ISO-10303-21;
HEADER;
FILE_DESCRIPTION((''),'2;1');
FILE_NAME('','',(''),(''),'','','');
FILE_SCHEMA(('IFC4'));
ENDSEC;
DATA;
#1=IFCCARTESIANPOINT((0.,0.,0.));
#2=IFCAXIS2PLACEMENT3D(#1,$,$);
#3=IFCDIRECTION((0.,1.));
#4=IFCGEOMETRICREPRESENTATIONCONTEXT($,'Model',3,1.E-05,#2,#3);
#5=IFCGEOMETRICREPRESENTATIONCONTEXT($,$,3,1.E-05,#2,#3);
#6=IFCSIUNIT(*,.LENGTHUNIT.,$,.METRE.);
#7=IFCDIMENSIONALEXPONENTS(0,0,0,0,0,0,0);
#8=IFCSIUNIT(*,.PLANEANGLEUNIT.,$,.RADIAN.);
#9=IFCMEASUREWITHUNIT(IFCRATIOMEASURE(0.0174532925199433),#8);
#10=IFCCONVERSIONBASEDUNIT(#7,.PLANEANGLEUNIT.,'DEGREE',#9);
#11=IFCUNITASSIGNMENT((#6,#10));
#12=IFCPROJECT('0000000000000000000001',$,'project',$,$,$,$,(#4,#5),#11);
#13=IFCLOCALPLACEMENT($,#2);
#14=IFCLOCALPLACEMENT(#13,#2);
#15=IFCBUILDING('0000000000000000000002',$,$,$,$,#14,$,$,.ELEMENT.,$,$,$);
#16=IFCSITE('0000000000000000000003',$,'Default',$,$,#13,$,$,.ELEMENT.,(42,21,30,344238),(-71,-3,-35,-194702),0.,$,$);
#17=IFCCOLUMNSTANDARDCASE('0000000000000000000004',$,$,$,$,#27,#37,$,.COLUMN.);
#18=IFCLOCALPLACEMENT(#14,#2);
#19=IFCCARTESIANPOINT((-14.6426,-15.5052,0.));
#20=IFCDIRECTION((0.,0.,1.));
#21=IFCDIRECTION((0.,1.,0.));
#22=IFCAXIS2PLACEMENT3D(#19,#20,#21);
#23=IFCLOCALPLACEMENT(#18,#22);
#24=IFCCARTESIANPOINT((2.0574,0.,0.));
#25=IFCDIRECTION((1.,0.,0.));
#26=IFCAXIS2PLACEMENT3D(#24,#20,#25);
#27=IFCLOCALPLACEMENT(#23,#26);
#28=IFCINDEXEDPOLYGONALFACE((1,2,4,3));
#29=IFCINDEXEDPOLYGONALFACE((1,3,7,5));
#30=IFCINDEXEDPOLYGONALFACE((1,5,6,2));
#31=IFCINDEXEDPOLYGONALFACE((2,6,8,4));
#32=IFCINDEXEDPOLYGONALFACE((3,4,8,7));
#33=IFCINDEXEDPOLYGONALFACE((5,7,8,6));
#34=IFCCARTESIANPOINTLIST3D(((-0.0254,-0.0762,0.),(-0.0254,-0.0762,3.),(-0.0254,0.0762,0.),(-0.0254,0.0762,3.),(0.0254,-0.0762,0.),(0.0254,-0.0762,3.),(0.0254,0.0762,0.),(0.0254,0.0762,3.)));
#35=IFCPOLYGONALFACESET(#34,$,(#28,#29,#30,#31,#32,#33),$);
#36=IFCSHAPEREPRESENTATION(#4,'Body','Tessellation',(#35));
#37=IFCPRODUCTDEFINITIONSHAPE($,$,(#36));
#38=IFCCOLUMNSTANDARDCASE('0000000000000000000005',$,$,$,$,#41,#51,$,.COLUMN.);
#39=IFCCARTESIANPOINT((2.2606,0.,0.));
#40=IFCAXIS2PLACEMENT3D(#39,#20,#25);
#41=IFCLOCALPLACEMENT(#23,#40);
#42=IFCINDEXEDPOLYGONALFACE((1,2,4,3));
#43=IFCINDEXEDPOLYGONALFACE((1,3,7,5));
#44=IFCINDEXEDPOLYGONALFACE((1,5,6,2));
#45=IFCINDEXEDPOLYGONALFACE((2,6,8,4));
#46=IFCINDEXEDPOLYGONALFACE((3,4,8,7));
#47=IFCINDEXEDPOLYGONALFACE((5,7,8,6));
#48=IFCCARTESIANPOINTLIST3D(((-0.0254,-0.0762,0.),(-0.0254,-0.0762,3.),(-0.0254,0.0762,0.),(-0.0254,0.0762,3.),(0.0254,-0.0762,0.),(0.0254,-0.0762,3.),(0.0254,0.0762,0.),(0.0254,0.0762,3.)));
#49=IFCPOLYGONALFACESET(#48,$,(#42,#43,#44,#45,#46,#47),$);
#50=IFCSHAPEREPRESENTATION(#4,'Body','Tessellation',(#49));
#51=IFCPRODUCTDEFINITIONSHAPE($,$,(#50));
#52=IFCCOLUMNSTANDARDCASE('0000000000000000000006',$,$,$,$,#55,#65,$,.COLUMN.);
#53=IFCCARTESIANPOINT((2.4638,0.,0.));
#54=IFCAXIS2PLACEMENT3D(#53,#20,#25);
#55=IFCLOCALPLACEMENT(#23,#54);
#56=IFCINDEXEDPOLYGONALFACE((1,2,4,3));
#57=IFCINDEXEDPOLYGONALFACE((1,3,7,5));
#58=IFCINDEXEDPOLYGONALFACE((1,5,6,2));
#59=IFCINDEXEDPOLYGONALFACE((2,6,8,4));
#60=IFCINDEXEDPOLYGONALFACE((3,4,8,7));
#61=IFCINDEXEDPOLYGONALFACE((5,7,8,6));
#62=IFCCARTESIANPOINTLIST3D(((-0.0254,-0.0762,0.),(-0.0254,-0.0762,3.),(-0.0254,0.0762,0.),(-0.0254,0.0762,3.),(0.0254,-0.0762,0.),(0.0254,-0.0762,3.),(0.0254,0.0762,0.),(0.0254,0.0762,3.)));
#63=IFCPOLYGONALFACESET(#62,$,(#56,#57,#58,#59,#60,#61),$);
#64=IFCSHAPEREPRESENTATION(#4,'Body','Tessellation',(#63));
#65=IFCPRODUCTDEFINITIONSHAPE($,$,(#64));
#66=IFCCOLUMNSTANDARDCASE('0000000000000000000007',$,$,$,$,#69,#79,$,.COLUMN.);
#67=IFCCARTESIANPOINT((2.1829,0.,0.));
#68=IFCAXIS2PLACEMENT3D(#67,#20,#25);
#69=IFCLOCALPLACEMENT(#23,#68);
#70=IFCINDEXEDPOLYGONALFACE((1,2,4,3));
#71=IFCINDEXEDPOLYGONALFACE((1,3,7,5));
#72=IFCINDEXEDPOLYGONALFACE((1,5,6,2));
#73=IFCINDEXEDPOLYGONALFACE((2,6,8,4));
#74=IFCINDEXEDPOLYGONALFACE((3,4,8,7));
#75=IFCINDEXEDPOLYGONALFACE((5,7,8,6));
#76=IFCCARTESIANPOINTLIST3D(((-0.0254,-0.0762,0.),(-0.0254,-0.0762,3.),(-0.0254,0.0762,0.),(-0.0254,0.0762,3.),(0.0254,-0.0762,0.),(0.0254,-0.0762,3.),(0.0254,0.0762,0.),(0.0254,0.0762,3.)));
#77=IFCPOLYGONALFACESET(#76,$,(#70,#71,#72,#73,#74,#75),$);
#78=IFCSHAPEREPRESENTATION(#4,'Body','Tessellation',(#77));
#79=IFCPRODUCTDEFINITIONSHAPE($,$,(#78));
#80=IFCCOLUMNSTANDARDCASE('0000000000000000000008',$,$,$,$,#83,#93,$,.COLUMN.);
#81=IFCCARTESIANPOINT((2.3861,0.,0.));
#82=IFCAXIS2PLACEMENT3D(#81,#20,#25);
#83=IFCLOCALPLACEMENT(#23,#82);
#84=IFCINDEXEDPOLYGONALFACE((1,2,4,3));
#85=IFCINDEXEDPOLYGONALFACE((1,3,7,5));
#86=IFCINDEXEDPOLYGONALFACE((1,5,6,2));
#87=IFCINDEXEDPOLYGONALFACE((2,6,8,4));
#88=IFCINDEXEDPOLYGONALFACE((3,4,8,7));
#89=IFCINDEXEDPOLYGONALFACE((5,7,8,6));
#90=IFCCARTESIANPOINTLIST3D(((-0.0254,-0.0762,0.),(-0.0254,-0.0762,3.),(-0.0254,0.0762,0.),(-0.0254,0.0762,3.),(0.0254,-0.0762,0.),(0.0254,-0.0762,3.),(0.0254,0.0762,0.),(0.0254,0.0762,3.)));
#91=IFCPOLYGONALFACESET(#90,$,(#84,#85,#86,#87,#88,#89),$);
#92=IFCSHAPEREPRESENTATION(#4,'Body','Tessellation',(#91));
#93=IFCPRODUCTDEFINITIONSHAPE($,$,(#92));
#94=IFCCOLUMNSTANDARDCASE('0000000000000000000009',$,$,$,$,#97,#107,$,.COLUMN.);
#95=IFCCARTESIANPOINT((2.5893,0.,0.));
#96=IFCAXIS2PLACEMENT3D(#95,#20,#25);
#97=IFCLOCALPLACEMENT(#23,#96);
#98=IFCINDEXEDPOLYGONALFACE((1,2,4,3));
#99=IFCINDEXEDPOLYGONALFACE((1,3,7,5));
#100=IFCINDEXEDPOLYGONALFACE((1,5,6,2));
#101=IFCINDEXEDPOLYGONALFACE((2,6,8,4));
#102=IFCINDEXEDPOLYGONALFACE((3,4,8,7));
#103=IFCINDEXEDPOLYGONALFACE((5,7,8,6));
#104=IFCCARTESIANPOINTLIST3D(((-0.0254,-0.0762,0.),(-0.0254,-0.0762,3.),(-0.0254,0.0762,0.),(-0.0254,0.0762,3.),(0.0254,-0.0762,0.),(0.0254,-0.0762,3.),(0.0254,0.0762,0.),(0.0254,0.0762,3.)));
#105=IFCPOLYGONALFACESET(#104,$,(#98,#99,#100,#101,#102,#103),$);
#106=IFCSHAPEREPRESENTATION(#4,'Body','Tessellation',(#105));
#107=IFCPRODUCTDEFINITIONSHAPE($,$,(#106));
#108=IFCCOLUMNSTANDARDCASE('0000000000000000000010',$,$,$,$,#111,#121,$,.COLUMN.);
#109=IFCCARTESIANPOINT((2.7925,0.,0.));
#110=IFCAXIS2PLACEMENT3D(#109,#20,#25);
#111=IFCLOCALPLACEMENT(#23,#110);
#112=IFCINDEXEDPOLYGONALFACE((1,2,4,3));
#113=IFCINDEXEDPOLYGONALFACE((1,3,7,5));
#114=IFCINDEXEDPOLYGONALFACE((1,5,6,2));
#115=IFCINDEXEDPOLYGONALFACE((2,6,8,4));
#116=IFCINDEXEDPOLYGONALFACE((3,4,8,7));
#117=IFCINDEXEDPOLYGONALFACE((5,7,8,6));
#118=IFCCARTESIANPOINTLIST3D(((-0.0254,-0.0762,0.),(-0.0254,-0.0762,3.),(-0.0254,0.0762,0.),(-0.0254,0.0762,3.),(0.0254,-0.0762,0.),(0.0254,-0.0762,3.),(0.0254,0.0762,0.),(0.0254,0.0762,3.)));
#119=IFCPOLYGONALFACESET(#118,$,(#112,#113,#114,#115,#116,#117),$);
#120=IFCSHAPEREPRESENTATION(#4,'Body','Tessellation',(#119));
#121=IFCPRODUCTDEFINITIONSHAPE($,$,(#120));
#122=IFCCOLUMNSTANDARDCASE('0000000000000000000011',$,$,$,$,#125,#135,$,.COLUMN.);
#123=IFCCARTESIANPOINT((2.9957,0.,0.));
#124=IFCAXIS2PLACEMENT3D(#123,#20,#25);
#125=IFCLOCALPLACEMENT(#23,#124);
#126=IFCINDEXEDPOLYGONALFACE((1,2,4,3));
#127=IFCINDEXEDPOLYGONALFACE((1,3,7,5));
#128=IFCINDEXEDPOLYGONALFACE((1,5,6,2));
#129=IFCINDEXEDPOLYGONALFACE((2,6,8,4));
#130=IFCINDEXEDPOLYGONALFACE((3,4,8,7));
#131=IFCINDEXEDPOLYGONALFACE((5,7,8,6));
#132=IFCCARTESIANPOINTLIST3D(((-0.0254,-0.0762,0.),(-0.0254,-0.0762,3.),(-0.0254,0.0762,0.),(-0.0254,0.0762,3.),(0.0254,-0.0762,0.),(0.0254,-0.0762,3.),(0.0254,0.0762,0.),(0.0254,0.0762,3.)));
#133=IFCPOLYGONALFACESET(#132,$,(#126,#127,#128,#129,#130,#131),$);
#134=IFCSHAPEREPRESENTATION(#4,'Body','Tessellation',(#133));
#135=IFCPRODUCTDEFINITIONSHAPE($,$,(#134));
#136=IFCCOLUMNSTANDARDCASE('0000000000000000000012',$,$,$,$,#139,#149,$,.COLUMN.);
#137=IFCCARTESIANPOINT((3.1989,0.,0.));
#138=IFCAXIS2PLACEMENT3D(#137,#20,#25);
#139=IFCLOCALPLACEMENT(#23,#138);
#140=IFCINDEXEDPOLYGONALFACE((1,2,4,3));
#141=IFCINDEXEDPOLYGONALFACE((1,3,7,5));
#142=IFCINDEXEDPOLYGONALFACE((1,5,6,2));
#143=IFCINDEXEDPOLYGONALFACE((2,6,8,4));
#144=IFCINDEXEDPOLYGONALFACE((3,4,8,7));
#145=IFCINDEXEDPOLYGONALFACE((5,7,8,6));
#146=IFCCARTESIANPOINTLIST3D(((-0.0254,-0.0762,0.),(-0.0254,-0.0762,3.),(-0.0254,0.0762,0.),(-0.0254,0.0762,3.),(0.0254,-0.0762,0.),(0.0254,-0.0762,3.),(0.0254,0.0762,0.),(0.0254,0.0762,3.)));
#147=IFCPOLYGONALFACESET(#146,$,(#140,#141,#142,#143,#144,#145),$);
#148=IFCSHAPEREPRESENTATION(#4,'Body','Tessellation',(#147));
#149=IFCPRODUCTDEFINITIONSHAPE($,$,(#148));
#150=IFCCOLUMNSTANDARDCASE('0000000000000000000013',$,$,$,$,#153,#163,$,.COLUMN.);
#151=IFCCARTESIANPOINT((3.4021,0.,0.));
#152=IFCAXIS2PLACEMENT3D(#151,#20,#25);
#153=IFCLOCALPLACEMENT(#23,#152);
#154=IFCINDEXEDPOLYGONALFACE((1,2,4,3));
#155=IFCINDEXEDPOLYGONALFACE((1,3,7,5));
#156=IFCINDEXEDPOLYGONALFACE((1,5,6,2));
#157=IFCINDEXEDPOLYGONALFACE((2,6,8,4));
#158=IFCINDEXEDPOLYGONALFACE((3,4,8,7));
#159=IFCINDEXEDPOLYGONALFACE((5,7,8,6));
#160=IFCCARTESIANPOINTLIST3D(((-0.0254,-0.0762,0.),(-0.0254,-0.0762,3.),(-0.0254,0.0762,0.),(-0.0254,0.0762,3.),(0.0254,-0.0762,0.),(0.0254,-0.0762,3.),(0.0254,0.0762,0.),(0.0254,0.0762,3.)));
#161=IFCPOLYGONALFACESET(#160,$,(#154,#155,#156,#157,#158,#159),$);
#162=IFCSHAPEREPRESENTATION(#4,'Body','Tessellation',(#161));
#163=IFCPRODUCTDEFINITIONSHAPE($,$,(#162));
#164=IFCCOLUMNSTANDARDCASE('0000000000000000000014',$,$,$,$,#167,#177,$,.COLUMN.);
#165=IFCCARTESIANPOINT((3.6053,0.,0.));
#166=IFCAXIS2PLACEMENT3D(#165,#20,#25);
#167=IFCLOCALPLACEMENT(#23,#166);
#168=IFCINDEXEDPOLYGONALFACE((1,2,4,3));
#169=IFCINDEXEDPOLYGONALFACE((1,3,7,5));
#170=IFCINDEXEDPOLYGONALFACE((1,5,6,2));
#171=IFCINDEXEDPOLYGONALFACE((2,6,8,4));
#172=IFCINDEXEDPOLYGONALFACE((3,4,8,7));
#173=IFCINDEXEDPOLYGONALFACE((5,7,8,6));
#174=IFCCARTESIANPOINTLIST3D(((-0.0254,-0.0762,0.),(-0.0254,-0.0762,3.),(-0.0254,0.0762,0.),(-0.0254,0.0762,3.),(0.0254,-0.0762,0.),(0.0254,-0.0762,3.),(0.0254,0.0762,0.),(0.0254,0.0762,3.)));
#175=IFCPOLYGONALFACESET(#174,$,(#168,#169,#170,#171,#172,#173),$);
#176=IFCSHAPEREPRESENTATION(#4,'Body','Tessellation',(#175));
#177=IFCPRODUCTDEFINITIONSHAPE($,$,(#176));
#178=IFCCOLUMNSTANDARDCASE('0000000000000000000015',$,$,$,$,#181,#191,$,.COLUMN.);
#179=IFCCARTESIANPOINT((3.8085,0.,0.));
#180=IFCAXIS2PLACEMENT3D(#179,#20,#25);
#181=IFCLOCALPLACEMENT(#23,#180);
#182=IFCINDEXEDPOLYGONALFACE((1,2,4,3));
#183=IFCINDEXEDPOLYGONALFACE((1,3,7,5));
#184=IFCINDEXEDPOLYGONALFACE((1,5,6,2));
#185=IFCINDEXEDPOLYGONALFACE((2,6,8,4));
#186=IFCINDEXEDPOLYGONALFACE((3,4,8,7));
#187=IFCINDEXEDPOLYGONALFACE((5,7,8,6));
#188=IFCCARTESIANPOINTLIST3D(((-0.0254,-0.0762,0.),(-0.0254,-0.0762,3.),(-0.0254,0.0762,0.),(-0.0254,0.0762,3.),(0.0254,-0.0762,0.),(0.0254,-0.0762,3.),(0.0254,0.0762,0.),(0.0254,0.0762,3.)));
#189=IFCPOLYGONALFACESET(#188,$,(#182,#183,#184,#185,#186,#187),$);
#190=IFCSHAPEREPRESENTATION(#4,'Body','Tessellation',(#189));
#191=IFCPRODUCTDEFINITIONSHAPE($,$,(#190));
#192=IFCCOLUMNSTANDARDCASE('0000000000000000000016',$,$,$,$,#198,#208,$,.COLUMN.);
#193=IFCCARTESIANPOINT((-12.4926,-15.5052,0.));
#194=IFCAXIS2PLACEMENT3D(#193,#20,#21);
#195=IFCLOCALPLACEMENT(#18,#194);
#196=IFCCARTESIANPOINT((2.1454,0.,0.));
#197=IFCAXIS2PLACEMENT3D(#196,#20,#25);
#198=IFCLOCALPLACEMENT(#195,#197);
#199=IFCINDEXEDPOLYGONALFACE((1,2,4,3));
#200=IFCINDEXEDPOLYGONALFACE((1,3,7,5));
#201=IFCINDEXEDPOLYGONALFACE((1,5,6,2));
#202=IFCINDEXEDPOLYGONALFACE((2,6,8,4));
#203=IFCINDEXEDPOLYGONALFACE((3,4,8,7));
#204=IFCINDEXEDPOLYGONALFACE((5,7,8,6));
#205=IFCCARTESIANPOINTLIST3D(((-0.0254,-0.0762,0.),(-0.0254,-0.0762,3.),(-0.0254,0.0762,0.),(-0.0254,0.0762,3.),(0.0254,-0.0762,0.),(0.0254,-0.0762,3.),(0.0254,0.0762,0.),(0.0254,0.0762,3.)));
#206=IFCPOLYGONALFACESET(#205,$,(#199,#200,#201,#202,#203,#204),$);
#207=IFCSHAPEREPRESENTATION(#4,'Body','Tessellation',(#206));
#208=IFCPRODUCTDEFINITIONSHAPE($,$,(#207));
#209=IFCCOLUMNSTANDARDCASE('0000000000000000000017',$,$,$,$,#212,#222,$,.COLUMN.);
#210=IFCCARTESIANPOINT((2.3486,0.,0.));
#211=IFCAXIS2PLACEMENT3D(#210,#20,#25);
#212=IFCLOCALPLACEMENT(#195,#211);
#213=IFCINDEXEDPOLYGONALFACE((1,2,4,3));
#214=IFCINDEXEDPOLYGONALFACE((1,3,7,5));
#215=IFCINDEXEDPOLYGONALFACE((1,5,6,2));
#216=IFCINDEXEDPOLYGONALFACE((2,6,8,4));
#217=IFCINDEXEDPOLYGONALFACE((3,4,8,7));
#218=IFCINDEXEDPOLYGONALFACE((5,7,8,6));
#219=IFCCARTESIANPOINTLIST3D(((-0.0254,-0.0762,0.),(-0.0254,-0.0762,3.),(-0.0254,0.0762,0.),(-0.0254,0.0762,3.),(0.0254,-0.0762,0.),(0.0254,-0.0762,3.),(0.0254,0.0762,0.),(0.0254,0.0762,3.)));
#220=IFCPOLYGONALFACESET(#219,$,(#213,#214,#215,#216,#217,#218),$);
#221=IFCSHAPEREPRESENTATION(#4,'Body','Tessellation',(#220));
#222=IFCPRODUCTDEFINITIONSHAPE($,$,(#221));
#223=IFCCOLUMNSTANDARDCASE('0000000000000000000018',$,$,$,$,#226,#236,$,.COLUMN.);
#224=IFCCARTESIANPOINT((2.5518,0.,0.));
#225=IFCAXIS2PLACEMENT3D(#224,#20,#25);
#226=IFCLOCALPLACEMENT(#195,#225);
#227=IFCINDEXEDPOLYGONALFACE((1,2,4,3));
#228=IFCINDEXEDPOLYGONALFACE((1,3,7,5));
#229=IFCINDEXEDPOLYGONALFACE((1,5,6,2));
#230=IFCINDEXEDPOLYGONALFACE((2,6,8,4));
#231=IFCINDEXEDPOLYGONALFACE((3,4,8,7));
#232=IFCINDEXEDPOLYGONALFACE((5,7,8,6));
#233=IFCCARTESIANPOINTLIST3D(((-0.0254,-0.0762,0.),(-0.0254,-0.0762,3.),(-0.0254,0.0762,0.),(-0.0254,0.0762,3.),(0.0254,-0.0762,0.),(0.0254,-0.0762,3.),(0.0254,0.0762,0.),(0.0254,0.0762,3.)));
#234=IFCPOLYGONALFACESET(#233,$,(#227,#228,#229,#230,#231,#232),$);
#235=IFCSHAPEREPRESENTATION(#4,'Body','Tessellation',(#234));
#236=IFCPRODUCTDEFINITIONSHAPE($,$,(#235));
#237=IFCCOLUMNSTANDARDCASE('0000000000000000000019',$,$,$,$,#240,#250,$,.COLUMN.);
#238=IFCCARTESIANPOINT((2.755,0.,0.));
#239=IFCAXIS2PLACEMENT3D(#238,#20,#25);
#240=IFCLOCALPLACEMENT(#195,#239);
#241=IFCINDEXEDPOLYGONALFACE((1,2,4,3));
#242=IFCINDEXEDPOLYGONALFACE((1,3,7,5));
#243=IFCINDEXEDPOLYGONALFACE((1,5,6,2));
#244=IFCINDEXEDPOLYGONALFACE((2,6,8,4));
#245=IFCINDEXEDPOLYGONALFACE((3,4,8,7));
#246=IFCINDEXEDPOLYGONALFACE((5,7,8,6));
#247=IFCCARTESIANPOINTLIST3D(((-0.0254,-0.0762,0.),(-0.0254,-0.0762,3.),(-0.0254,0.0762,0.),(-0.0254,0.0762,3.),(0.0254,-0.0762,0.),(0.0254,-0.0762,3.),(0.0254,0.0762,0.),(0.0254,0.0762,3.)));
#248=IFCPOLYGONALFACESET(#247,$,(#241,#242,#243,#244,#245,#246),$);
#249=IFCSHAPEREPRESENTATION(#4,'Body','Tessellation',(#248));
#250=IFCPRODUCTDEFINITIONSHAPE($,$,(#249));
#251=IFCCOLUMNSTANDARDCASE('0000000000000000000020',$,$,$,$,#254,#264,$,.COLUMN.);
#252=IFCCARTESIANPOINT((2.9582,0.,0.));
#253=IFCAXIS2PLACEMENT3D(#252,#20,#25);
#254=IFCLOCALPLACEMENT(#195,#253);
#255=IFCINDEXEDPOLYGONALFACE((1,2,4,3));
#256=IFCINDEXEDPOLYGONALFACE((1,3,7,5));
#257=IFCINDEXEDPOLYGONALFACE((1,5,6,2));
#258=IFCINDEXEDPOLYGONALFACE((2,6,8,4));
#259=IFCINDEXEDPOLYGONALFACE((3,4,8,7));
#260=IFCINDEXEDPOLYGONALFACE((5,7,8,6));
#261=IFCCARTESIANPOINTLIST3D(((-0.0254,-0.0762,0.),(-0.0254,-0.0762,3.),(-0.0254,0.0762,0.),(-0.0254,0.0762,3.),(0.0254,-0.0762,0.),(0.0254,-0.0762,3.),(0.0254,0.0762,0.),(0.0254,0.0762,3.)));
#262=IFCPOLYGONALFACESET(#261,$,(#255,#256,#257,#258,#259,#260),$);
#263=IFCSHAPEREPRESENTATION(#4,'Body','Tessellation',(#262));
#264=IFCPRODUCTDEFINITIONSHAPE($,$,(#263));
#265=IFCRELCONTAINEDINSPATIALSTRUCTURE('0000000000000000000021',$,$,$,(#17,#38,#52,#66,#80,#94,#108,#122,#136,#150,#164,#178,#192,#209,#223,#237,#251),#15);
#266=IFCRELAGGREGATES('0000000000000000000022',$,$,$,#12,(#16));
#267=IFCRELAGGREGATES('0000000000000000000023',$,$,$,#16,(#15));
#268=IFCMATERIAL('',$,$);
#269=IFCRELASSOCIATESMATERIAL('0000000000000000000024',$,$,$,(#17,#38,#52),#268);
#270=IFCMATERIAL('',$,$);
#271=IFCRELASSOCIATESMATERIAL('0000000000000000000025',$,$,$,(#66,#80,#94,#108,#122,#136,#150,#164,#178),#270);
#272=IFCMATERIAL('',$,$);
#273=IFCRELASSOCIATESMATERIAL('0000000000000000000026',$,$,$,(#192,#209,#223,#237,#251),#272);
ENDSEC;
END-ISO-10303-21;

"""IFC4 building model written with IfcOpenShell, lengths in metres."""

from ifc_helpers import new_model, entity, si_unit, converted_unit, direction, frame, origin, place, context, project, spatial, rectangle, extrude, material, element, save


model = new_model("IFC4")

# Units and contexts
model_context = context("Model", 3, precision=1e-05, world=origin(), true_north=direction((0.0, 1.0)))
context_of_model = context(None, 3, precision=1e-05, world=origin(), true_north=direction((0.0, 1.0)))
ifc_project = project(units=[si_unit("LENGTHUNIT", "METRE"), converted_unit("PLANEANGLEUNIT", "DEGREE", entity("IfcRatioMeasure", 0.0174532925199433), si_unit("PLANEANGLEUNIT", "RADIAN"), dimensions=[0, 0, 0, 0, 0, 0, 0])], contexts=[model_context, context_of_model])

# Site, building
site_placement = place(None, origin())
site = spatial("IfcSite", under=ifc_project, at=site_placement, Name="Default", CompositionType="ELEMENT", RefLatitude=(42, 21, 30, 344238), RefLongitude=(-71, -3, -35, -194702), RefElevation=0.0)
building_placement = place(site_placement, origin())
building = spatial("IfcBuilding", under=site, at=building_placement, CompositionType="ELEMENT")

# Columns
ifc_material_1 = material(Name="")
placement_1 = place(building_placement, origin())
placement_2 = place(placement_1, frame((-14.6426, -15.5052, 0.0), z_axis=(0.0, 0.0, 1.0), x_axis=(0.0, 1.0, 0.0)))
for number, where, z_axis, x_axis in (
    (1, (2.0574, 0.0, 0.0), (0.0, 0.0, 1.0), (1.0, 0.0, 0.0)),
    (2, (2.2606, 0.0, 0.0), (0.0, 0.0, 1.0), (1.0, 0.0, 0.0)),
    (3, (2.4638, 0.0, 0.0), (0.0, 0.0, 1.0), (1.0, 0.0, 0.0)),
):
    element("IfcColumnStandardCase", number, at=place(placement_2, frame(where, z_axis=z_axis, x_axis=x_axis)), inside=building, material=ifc_material_1, PredefinedType="COLUMN", context=model_context, shape_type="SweptSolid", body=[
        extrude(rectangle(XDim=0.0508, YDim=0.1524), origin(), (0.0, 0.0, 1.0), 3.0),
    ])
ifc_material_2 = material(Name="")
for number, where, z_axis, x_axis in (
    (4, (2.1829, 0.0, 0.0), (0.0, 0.0, 1.0), (1.0, 0.0, 0.0)),
    (5, (2.3861, 0.0, 0.0), (0.0, 0.0, 1.0), (1.0, 0.0, 0.0)),
    (6, (2.5893, 0.0, 0.0), (0.0, 0.0, 1.0), (1.0, 0.0, 0.0)),
    (7, (2.7925, 0.0, 0.0), (0.0, 0.0, 1.0), (1.0, 0.0, 0.0)),
    (8, (2.9957, 0.0, 0.0), (0.0, 0.0, 1.0), (1.0, 0.0, 0.0)),
    (9, (3.1989, 0.0, 0.0), (0.0, 0.0, 1.0), (1.0, 0.0, 0.0)),
    (10, (3.4021, 0.0, 0.0), (0.0, 0.0, 1.0), (1.0, 0.0, 0.0)),
    (11, (3.6053, 0.0, 0.0), (0.0, 0.0, 1.0), (1.0, 0.0, 0.0)),
    (12, (3.8085, 0.0, 0.0), (0.0, 0.0, 1.0), (1.0, 0.0, 0.0)),
):
    element("IfcColumnStandardCase", number, at=place(placement_2, frame(where, z_axis=z_axis, x_axis=x_axis)), inside=building, material=ifc_material_2, PredefinedType="COLUMN", context=model_context, shape_type="SweptSolid", body=[
        extrude(rectangle(XDim=0.0508, YDim=0.1524), origin(), (0.0, 0.0, 1.0), 3.0),
    ])
ifc_material_3 = material(Name="")
placement_3 = place(placement_1, frame((-12.4926, -15.5052, 0.0), z_axis=(0.0, 0.0, 1.0), x_axis=(0.0, 1.0, 0.0)))
for number, where, z_axis, x_axis in (
    (13, (2.1454, 0.0, 0.0), (0.0, 0.0, 1.0), (1.0, 0.0, 0.0)),
    (14, (2.3486, 0.0, 0.0), (0.0, 0.0, 1.0), (1.0, 0.0, 0.0)),
    (15, (2.5518, 0.0, 0.0), (0.0, 0.0, 1.0), (1.0, 0.0, 0.0)),
    (16, (2.755, 0.0, 0.0), (0.0, 0.0, 1.0), (1.0, 0.0, 0.0)),
    (17, (2.9582, 0.0, 0.0), (0.0, 0.0, 1.0), (1.0, 0.0, 0.0)),
):
    element("IfcColumnStandardCase", number, at=place(placement_3, frame(where, z_axis=z_axis, x_axis=x_axis)), inside=building, material=ifc_material_3, PredefinedType="COLUMN", context=model_context, shape_type="SweptSolid", body=[
        extrude(rectangle(XDim=0.0508, YDim=0.1524), origin(), (0.0, 0.0, 1.0), 3.0),
    ])

save(model, "model.ifc")
